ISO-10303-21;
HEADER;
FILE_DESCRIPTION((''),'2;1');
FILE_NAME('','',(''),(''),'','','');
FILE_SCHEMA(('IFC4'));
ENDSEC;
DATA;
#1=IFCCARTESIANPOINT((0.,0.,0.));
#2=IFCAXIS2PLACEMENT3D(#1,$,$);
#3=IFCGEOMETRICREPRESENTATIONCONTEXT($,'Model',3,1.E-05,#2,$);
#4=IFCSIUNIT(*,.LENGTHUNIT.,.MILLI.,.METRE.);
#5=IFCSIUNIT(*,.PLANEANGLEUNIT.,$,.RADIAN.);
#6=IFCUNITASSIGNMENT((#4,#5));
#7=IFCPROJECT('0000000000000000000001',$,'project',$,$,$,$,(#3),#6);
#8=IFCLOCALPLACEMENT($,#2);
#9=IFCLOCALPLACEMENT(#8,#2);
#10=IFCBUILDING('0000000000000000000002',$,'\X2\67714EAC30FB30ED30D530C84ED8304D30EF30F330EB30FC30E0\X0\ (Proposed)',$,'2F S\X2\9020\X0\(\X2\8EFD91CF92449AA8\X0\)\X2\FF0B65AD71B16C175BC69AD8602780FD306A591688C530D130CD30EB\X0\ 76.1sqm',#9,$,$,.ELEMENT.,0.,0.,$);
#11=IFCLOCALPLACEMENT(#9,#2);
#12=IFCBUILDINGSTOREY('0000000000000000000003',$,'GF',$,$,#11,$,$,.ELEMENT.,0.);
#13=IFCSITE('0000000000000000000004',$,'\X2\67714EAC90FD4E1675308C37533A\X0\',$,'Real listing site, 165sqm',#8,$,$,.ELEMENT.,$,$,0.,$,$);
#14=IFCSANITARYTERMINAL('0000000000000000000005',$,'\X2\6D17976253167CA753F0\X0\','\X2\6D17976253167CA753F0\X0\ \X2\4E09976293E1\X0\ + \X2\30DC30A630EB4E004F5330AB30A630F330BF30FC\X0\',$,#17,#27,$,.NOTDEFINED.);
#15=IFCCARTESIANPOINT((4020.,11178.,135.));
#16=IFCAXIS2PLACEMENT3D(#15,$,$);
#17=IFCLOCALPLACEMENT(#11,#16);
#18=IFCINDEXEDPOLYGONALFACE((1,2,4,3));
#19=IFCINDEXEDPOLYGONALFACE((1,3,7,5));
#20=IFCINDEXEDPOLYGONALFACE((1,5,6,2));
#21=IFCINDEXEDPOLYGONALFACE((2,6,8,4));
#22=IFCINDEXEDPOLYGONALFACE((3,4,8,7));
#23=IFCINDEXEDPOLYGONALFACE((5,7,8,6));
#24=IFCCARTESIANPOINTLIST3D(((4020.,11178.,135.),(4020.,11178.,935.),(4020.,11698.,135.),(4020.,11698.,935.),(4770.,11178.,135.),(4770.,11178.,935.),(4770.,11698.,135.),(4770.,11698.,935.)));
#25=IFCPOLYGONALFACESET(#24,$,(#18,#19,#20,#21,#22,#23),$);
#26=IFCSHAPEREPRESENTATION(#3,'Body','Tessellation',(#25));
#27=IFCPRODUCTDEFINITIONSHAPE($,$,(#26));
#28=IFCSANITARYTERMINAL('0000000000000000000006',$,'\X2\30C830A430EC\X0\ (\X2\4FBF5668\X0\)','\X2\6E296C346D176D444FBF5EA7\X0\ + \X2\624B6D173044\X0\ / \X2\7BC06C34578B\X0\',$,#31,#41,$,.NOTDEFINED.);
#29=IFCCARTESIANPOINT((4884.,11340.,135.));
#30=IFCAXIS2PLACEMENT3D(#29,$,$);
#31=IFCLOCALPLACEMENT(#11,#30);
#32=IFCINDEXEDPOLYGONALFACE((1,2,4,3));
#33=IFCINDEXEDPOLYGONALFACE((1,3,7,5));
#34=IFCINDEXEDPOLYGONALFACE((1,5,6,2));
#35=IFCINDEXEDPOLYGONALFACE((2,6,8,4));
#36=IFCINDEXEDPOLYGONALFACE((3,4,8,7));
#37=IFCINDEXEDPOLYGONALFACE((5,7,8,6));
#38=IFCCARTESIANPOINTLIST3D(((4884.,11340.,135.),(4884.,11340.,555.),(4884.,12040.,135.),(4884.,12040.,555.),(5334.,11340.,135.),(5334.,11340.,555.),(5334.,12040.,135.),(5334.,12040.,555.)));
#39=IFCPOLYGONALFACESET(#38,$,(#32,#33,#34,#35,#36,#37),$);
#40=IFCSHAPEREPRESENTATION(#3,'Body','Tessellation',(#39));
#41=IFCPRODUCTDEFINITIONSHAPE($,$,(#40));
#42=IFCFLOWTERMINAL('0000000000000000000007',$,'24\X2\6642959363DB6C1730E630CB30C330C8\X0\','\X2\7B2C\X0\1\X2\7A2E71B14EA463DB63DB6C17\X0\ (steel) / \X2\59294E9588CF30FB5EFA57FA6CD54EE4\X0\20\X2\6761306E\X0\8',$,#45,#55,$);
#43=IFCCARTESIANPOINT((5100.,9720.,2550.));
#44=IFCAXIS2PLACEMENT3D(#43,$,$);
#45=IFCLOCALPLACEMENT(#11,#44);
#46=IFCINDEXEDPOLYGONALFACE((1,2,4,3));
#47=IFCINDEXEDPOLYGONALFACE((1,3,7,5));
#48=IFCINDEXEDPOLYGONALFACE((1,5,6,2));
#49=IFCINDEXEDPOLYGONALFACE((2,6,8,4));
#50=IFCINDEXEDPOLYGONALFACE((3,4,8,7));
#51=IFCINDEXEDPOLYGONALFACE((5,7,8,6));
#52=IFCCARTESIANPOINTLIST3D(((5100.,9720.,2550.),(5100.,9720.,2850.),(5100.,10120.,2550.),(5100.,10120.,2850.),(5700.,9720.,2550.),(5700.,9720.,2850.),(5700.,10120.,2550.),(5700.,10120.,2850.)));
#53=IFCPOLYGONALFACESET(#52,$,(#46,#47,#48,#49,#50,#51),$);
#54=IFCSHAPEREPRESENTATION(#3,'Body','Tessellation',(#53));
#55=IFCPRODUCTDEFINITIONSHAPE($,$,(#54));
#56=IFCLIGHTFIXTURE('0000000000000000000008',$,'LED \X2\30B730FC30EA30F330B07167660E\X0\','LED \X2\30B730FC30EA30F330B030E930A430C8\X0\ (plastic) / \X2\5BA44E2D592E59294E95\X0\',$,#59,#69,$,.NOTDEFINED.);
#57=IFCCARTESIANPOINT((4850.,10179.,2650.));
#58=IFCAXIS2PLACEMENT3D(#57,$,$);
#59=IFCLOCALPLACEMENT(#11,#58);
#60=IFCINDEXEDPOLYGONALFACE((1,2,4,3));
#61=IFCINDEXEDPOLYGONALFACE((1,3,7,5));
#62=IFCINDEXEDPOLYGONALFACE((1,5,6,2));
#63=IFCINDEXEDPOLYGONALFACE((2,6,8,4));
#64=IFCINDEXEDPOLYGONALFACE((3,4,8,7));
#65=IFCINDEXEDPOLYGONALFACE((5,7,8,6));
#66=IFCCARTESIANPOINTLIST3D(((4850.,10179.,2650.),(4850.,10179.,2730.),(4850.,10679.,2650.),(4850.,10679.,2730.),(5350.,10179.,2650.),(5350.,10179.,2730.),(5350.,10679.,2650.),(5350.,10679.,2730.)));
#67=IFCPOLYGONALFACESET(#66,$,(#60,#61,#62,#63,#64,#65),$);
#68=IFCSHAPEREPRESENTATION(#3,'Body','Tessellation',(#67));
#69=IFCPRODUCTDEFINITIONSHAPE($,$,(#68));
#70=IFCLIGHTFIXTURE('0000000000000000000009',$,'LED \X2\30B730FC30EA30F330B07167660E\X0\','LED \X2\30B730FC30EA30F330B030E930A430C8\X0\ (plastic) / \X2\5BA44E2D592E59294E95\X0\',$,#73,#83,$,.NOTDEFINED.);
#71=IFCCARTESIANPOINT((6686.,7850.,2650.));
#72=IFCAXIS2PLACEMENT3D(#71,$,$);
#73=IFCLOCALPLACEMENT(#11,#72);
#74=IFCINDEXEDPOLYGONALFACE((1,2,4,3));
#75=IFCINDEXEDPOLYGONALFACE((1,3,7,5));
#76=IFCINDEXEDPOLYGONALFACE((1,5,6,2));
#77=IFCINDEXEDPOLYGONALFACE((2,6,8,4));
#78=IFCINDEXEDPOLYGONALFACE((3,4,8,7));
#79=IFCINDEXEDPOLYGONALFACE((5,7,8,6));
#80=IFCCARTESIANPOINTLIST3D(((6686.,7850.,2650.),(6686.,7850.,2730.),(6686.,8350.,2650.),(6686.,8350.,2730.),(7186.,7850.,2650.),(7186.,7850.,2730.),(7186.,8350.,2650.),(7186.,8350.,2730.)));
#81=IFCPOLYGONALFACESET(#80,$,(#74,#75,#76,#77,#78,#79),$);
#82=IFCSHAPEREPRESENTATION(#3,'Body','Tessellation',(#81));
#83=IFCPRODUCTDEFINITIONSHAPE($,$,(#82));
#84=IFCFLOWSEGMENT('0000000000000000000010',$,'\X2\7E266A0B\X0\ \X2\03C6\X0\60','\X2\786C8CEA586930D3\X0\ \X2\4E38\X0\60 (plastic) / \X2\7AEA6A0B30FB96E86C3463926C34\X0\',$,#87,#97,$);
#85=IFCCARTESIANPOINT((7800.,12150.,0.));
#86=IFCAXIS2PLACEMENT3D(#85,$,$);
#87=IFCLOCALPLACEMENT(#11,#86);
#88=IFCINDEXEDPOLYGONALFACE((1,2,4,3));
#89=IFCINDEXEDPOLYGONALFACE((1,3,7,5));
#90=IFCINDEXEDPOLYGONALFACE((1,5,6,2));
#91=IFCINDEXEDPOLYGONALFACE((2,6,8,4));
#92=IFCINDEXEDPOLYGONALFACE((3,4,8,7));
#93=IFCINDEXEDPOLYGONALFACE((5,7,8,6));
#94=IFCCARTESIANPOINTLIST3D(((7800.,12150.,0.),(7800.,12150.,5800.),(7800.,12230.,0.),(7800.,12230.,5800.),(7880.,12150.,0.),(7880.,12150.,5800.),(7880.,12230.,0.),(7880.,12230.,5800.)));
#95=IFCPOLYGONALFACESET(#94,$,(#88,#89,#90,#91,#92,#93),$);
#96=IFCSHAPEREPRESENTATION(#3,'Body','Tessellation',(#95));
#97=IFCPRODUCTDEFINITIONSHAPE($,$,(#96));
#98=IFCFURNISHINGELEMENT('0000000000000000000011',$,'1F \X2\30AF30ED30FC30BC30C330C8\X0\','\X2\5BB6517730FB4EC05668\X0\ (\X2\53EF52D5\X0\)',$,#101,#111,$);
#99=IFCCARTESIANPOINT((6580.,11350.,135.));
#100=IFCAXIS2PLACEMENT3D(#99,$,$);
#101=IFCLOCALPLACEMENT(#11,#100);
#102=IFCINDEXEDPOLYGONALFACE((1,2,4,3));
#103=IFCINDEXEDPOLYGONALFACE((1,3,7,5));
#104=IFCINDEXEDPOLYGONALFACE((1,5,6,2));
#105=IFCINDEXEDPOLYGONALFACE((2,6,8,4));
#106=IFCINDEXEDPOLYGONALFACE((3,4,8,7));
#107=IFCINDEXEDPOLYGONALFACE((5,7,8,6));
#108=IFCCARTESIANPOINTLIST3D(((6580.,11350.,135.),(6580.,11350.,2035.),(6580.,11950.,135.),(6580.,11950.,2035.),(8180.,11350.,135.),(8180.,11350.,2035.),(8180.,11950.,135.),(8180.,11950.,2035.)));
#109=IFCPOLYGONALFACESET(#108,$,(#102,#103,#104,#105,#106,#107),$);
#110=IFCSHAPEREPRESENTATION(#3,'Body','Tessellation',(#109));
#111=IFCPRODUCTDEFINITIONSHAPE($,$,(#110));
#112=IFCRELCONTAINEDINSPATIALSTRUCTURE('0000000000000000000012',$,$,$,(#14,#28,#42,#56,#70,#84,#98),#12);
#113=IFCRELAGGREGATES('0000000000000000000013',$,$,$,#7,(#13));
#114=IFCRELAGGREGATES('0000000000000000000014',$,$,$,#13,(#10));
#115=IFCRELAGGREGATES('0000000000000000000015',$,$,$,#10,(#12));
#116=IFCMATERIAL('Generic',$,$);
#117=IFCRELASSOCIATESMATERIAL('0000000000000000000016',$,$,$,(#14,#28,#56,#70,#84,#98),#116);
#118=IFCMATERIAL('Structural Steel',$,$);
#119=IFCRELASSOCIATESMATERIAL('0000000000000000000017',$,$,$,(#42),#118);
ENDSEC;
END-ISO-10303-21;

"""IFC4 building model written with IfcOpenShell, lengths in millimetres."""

from ifc_helpers import new_model, si_unit, frame, frame_2d, origin, place, context, project, spatial, rectangle, extrude, material, element, save


model = new_model("IFC4")

# Units and contexts
model_context = context("Model", 3, precision=1e-05, world=origin())
ifc_project = project(units=[si_unit("LENGTHUNIT", "METRE", prefix="MILLI"), si_unit("PLANEANGLEUNIT", "RADIAN")], contexts=[model_context])

# Site, building, storey
site_placement = place(None, origin())
site = spatial("IfcSite", under=ifc_project, at=site_placement, Name="東京都世田谷区", ObjectType="Real listing site, 165sqm", CompositionType="ELEMENT", RefElevation=0.0)
building_placement = place(site_placement, origin())
building = spatial("IfcBuilding", under=site, at=building_placement, Name="東京・ロフト付きワンルーム (Proposed)", ObjectType="2F S造(軽量鉄骨)＋断熱気密高性能な外装パネル 76.1sqm", CompositionType="ELEMENT", ElevationOfRefHeight=0.0, ElevationOfTerrain=0.0)
storey_placement = place(building_placement, origin())
storey = spatial("IfcBuildingStorey", under=building, at=storey_placement, Name="GF", CompositionType="ELEMENT", Elevation=0.0)

# Shared definitions
ifc_material_1 = material(Name="Generic")

# Sanitary terminals
sanitary_terminal_1_placement = place(storey_placement, frame((4020.0, 11178.0, 135.0)))
element("IfcSanitaryTerminal", 1, at=sanitary_terminal_1_placement, inside=storey, material=ifc_material_1, Name="洗面化粧台", Description="洗面化粧台 三面鏡 + ボウル一体カウンター", PredefinedType="NOTDEFINED", context=model_context, shape_type="SweptSolid", body=[
    extrude(rectangle(XDim=750.0, YDim=520.0, at=frame_2d((375.0, 260.0))), frame((4020.0, 11178.0, 135.0)), (0.0, 0.0, 1.0), 800.0),
])
sanitary_terminal_2_placement = place(storey_placement, frame((4884.0, 11340.0, 135.0)))
element("IfcSanitaryTerminal", 2, at=sanitary_terminal_2_placement, inside=storey, material=ifc_material_1, Name="トイレ (便器)", Description="温水洗浄便座 + 手洗い / 節水型", PredefinedType="NOTDEFINED", context=model_context, shape_type="SweptSolid", body=[
    extrude(rectangle(XDim=450.0, YDim=700.0, at=frame_2d((225.0, 350.0))), frame((4884.0, 11340.0, 135.0)), (0.0, 0.0, 1.0), 420.0),
])

# Flow terminal
ifc_material_2 = material(Name="Structural Steel")
flow_terminal_placement = place(storey_placement, frame((5100.0, 9720.0, 2550.0)))
element("IfcFlowTerminal", 3, at=flow_terminal_placement, inside=storey, material=ifc_material_2, Name="24時間換気ユニット", Description="第1種熱交換換気 (steel) / 天井裏・建基法令20条の8", context=model_context, shape_type="SweptSolid", body=[
    extrude(rectangle(XDim=600.0, YDim=400.0, at=frame_2d((300.0, 200.0))), frame((5100.0, 9720.0, 2550.0)), (0.0, 0.0, 1.0), 300.0),
])

# Light fixtures
light_fixture_1_placement = place(storey_placement, frame((4850.0, 10179.0, 2650.0)))
element("IfcLightFixture", 4, at=light_fixture_1_placement, inside=storey, material=ifc_material_1, Name="LED シーリング照明", Description="LED シーリングライト (plastic) / 室中央天井", PredefinedType="NOTDEFINED", context=model_context, shape_type="SweptSolid", body=[
    extrude(rectangle(XDim=500.0, YDim=500.0, at=frame_2d((250.0, 250.0))), frame((4850.0, 10179.0, 2650.0)), (0.0, 0.0, 1.0), 80.0),
])
light_fixture_2_placement = place(storey_placement, frame((6686.0, 7850.0, 2650.0)))
element("IfcLightFixture", 5, at=light_fixture_2_placement, inside=storey, material=ifc_material_1, Name="LED シーリング照明", Description="LED シーリングライト (plastic) / 室中央天井", PredefinedType="NOTDEFINED", context=model_context, shape_type="SweptSolid", body=[
    extrude(rectangle(XDim=500.0, YDim=500.0, at=frame_2d((250.0, 250.0))), frame((6686.0, 7850.0, 2650.0)), (0.0, 0.0, 1.0), 80.0),
])

# Flow segment
flow_segment_placement = place(storey_placement, frame((7800.0, 12150.0, 0.0)))
element("IfcFlowSegment", 6, at=flow_segment_placement, inside=storey, material=ifc_material_1, Name="縦樋 φ60", Description="硬質塩ビ 丸60 (plastic) / 竪樋・雨水排水", context=model_context, shape_type="SweptSolid", body=[
    extrude(rectangle(XDim=80.0, YDim=80.0, at=frame_2d((40.0, 40.0))), frame((7800.0, 12150.0, 0.0)), (0.0, 0.0, 1.0), 5800.0),
])

# Furnishing element
furnishing_placement = place(storey_placement, frame((6580.0, 11350.0, 135.0)))
element("IfcFurnishingElement", 7, at=furnishing_placement, inside=storey, material=ifc_material_1, Name="1F クローゼット", Description="家具・什器 (可動)", context=model_context, shape_type="SweptSolid", body=[
    extrude(rectangle(XDim=1600.0, YDim=600.0, at=frame_2d((800.0, 300.0))), frame((6580.0, 11350.0, 135.0)), (0.0, 0.0, 1.0), 1900.0),
])

save(model, "model.ifc")
